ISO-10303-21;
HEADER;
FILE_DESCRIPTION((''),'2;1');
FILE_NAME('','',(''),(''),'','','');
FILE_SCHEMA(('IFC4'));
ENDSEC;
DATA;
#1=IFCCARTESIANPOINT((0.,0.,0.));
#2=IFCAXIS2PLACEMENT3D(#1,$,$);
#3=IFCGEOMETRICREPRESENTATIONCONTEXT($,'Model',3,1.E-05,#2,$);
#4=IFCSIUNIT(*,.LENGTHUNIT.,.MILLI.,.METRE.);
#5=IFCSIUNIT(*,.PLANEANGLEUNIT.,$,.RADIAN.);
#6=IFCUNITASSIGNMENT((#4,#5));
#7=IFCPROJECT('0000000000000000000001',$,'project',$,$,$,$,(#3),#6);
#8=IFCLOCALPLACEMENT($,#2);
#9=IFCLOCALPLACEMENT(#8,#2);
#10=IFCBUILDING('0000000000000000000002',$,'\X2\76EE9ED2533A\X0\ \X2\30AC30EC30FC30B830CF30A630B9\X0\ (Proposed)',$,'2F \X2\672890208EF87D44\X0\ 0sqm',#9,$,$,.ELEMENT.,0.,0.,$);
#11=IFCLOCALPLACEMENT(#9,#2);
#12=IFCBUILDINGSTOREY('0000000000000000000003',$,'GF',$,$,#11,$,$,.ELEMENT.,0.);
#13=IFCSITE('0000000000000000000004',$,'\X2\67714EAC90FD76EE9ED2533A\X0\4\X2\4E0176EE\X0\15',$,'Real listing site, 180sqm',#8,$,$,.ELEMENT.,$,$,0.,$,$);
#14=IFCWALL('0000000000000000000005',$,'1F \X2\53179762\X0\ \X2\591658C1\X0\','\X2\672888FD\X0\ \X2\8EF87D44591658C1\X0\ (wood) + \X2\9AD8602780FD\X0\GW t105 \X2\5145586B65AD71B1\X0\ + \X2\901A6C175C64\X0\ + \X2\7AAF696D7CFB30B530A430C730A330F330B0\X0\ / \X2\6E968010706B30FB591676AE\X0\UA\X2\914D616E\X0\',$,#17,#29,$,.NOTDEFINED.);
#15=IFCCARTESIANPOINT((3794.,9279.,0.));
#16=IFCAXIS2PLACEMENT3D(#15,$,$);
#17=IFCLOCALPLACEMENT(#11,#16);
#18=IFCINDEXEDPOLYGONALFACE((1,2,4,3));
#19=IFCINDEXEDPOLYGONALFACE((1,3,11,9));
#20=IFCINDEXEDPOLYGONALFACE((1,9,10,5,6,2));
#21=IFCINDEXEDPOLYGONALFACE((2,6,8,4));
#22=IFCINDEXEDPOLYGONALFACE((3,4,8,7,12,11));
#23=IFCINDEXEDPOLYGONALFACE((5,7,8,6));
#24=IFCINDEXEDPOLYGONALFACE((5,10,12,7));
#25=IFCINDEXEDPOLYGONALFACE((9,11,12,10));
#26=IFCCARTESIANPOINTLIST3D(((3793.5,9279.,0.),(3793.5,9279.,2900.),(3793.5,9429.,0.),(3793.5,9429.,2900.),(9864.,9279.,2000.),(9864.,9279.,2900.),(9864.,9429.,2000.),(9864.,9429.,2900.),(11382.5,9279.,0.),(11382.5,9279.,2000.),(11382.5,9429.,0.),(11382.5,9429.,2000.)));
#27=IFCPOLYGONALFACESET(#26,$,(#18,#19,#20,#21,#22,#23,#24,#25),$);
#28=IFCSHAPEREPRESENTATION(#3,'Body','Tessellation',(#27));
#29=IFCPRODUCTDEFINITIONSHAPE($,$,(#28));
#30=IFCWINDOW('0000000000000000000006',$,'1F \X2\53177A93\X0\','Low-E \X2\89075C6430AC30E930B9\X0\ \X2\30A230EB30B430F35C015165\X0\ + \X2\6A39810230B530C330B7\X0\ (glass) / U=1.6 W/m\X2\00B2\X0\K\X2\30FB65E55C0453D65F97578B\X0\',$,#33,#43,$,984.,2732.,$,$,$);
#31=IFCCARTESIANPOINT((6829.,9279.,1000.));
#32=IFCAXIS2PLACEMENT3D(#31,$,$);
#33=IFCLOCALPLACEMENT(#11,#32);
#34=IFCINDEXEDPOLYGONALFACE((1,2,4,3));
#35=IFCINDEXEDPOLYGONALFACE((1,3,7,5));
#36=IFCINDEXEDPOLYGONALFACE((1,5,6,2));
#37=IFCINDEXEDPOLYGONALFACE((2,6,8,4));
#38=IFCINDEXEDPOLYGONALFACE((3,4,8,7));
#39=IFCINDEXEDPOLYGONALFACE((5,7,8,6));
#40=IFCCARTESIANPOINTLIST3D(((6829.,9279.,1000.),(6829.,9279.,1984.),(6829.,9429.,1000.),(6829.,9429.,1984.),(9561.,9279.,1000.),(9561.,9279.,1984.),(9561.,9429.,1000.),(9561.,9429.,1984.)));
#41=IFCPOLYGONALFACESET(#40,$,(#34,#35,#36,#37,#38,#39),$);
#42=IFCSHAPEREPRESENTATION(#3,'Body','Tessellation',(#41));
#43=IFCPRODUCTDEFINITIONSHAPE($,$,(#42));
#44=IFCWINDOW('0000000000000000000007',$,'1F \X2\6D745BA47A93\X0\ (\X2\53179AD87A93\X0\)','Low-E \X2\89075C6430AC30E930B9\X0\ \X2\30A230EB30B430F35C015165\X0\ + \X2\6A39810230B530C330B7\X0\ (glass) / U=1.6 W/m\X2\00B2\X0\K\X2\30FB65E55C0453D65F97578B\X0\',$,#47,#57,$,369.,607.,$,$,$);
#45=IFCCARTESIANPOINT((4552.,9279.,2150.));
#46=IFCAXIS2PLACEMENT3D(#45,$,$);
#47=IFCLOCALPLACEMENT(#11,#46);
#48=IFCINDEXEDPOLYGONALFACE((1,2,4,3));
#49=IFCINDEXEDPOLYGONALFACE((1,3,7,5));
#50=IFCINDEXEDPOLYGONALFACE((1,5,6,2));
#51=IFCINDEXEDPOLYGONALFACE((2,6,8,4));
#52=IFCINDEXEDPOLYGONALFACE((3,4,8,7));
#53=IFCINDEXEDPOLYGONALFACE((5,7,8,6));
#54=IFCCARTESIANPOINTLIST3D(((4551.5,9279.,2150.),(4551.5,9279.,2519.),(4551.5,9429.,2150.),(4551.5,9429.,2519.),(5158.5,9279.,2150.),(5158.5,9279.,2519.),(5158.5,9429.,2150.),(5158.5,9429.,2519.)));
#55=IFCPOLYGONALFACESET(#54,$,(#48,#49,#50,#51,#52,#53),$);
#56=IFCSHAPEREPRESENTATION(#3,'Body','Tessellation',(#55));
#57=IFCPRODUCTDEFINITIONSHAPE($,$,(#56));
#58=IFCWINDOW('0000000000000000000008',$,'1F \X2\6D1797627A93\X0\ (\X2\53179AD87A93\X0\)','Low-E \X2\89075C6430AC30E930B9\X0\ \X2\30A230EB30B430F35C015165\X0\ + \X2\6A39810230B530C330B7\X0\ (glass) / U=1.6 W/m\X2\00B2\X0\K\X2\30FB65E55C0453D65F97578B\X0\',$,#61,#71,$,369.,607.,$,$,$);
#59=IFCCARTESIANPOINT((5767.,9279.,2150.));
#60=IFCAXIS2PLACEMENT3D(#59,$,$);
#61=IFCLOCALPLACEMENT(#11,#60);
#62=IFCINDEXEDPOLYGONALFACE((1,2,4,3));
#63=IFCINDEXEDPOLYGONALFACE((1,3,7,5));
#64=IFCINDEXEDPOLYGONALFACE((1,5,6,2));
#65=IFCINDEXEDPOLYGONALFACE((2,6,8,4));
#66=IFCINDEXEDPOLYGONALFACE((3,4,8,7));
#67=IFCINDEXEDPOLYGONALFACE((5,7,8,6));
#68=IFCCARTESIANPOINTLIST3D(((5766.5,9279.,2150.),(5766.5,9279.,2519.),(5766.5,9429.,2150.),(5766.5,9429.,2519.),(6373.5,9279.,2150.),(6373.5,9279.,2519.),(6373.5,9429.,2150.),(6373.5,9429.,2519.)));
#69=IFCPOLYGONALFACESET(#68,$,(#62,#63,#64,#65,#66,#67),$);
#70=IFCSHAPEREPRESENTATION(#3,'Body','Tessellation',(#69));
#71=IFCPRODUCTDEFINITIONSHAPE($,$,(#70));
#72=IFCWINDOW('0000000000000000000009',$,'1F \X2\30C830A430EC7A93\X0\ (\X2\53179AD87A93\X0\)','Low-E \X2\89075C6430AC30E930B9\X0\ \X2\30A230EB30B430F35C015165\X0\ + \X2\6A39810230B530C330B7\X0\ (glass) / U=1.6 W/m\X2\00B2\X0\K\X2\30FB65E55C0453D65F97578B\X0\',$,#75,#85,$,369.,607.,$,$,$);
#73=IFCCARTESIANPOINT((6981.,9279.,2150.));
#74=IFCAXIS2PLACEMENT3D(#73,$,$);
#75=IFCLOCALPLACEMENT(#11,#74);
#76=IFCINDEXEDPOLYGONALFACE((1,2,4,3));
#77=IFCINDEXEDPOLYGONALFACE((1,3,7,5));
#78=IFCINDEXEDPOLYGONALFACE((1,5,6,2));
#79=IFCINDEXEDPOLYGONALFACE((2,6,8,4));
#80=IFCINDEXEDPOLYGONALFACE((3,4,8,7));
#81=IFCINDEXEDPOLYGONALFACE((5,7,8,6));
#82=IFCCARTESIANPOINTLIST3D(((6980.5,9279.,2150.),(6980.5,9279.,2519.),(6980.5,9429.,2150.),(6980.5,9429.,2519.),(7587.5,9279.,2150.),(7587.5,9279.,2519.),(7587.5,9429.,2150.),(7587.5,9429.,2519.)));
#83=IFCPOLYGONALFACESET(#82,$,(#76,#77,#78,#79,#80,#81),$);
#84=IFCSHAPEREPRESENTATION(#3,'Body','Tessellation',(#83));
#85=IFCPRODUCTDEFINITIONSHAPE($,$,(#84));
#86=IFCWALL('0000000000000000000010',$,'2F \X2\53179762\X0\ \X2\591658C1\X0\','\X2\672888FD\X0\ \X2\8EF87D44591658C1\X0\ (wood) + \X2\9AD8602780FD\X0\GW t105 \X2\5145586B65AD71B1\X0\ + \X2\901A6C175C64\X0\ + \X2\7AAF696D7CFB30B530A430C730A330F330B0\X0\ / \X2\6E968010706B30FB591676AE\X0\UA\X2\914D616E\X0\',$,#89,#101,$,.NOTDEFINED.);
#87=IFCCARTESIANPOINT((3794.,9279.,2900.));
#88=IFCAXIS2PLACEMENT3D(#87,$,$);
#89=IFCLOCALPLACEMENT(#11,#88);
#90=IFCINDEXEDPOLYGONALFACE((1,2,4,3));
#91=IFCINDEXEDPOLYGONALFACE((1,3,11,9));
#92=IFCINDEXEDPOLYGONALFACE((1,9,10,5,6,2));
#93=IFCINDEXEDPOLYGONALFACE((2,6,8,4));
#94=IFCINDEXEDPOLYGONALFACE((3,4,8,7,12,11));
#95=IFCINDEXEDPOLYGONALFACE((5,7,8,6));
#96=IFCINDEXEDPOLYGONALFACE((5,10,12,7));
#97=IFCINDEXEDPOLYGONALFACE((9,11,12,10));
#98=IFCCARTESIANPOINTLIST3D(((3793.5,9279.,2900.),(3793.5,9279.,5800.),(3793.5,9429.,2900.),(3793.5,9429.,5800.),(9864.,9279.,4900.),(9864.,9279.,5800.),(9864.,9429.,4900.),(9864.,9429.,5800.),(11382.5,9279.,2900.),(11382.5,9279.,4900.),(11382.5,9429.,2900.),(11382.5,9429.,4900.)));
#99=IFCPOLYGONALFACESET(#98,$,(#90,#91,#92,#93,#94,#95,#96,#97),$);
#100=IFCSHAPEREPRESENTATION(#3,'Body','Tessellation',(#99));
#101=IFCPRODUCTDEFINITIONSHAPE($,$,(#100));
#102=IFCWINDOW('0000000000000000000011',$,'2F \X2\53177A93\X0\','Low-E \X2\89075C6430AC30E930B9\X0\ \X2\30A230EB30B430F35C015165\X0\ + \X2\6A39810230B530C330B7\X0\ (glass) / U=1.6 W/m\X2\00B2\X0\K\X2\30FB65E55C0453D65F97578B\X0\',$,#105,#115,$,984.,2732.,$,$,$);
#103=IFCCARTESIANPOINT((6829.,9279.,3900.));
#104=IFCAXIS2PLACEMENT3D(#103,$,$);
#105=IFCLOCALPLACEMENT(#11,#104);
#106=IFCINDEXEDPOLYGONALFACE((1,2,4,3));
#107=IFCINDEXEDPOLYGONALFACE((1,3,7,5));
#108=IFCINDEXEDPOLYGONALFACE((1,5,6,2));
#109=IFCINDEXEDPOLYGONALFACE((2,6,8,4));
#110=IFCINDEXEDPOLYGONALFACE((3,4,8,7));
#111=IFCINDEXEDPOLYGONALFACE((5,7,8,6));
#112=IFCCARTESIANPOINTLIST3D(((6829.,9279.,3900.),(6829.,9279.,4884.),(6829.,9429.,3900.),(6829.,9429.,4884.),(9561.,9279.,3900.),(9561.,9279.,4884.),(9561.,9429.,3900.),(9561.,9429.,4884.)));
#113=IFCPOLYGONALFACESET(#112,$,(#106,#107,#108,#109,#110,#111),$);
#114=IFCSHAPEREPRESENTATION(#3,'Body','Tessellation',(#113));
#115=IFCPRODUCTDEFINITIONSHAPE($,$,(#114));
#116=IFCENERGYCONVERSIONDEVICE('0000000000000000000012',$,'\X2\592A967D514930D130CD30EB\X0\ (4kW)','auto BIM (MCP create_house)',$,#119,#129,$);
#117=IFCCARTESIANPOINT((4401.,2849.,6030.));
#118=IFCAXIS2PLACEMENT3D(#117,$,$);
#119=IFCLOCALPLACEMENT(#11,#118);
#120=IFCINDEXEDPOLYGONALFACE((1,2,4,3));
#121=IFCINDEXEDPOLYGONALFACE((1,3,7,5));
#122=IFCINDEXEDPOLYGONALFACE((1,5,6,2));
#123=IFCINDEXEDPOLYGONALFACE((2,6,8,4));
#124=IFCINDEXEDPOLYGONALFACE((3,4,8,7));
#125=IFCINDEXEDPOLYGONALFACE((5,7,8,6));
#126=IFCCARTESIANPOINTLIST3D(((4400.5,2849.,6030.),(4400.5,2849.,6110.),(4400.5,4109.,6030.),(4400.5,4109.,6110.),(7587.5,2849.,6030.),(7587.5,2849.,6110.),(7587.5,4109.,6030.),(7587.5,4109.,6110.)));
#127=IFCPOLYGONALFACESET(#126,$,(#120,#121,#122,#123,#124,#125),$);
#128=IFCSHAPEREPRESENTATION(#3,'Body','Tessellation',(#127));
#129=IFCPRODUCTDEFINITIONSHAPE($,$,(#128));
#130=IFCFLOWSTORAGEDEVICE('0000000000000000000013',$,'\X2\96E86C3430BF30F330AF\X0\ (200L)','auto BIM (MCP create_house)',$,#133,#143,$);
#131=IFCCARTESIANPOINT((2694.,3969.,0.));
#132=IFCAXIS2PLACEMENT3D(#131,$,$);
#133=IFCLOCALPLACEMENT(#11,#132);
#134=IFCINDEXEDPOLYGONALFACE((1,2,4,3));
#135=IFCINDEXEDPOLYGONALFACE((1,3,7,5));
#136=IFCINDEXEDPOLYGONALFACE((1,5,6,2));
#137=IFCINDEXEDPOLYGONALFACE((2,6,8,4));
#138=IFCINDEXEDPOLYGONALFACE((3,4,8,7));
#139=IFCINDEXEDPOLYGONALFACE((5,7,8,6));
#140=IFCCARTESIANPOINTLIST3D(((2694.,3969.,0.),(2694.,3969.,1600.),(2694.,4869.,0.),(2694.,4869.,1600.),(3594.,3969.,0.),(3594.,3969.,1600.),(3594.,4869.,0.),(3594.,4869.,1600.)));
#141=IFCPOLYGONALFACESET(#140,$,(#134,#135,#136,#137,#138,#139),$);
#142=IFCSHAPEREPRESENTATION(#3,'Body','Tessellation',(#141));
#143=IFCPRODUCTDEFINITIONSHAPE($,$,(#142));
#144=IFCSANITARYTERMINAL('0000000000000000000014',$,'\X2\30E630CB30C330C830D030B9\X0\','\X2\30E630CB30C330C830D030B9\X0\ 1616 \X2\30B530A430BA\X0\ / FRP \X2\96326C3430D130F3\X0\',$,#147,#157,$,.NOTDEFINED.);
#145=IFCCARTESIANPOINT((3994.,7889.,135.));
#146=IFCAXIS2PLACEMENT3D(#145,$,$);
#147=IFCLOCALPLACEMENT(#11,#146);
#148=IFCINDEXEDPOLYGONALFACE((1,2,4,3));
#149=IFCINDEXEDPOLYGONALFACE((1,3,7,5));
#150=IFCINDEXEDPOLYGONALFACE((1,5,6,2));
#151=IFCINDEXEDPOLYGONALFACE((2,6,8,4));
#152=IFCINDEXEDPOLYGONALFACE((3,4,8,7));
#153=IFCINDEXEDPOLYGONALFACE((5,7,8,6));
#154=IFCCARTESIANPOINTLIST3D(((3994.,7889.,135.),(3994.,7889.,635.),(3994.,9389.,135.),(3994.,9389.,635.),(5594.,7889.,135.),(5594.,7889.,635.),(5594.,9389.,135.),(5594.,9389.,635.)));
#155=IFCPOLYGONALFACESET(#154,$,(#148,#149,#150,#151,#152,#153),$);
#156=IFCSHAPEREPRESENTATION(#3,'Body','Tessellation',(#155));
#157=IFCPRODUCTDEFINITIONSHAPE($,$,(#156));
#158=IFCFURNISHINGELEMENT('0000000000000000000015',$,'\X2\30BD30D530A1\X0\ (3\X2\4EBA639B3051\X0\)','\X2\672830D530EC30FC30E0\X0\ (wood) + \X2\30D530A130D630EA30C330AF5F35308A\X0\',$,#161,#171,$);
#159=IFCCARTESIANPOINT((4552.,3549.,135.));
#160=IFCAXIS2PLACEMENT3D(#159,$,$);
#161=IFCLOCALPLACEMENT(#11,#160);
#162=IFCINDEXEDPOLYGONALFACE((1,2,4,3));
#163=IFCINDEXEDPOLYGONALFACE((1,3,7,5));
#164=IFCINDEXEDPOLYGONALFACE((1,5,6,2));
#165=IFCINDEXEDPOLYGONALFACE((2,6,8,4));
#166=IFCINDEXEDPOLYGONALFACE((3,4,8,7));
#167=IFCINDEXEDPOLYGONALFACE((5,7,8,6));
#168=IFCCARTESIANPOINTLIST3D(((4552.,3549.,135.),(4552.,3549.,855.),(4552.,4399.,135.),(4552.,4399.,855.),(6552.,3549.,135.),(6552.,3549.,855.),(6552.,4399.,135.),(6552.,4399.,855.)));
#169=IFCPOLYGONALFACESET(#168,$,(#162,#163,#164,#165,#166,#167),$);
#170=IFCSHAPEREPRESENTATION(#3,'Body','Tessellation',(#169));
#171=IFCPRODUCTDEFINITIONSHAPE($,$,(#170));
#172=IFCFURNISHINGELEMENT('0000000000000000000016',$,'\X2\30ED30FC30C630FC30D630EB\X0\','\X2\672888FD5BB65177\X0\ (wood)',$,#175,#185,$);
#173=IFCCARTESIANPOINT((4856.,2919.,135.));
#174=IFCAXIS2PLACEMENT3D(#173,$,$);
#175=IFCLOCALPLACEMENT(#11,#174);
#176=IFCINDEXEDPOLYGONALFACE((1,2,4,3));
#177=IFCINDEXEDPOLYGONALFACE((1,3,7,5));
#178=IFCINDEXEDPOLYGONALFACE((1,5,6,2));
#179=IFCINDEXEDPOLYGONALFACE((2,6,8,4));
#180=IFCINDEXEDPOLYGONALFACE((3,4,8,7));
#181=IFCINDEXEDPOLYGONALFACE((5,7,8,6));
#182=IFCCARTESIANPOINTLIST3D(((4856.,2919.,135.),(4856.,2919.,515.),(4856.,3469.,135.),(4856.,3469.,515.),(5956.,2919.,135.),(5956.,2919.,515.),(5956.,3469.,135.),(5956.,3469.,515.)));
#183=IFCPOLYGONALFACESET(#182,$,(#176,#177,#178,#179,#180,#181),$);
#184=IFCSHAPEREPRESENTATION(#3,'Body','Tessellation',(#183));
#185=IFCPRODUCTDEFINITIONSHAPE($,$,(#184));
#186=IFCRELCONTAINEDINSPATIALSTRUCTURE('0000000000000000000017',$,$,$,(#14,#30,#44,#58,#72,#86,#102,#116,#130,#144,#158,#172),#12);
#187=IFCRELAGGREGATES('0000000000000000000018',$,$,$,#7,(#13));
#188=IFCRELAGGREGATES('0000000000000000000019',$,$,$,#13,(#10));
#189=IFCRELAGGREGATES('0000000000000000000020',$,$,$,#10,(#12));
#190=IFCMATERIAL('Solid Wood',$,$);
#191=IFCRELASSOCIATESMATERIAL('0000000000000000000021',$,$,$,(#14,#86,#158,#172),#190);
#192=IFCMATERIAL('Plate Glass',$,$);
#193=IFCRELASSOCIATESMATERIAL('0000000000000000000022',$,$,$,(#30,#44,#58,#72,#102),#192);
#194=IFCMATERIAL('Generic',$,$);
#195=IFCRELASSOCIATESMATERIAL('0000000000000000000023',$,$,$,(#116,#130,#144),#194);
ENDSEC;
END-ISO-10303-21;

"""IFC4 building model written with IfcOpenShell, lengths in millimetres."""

from ifc_helpers import new_model, si_unit, frame, frame_2d, origin, place, context, project, spatial, rectangle, extrude, material, element, fill, save


model = new_model("IFC4")

# Units and contexts
model_context = context("Model", 3, precision=1e-05, world=origin())
ifc_project = project(units=[si_unit("LENGTHUNIT", "METRE", prefix="MILLI"), si_unit("PLANEANGLEUNIT", "RADIAN")], contexts=[model_context])

# Site, building, storey
site_placement = place(None, origin())
site = spatial("IfcSite", under=ifc_project, at=site_placement, Name="東京都目黒区4丁目15", ObjectType="Real listing site, 180sqm", CompositionType="ELEMENT", RefElevation=0.0)
building_placement = place(site_placement, origin())
building = spatial("IfcBuilding", under=site, at=building_placement, Name="目黒区 ガレージハウス (Proposed)", ObjectType="2F 木造軸組 0sqm", CompositionType="ELEMENT", ElevationOfRefHeight=0.0, ElevationOfTerrain=0.0)
storey_placement = place(building_placement, origin())
storey = spatial("IfcBuildingStorey", under=building, at=storey_placement, Name="GF", CompositionType="ELEMENT", Elevation=0.0)

# Wall, openings, windows
ifc_material_1 = material(Name="Solid Wood")
wall_1_placement = place(storey_placement, frame((3794.0, 9279.0, 0.0)))
wall_1 = element("IfcWall", 1, at=wall_1_placement, inside=storey, material=ifc_material_1, Name="1F 北面 外壁", Description="木製 軸組外壁 (wood) + 高性能GW t105 充填断熱 + 通気層 + 窯業系サイディング / 準耐火・外皮UA配慮", PredefinedType="NOTDEFINED", context=model_context, shape_type="SweptSolid", body=[
    extrude(rectangle(XDim=7589.0, YDim=150.0, at=frame_2d((3794.0, 75.0))), frame((3794.0, 9279.0, 0.0)), (0.0, 0.0, 1.0), 2900.0),
])
opening_1_placement = place(storey_placement, frame((6829.0, 9279.0, 1000.0)))
opening_1 = element("IfcOpeningElement", 2, at=opening_1_placement, cuts=wall_1, PredefinedType="NOTDEFINED", context=model_context, shape_type="SweptSolid", body=[
    extrude(rectangle(XDim=2732.0, YDim=150.0, at=frame_2d((1366.0, 75.0))), frame((6829.0, 9279.0, 1000.0)), (0.0, 0.0, 1.0), 984.0),
])
opening_2_placement = place(storey_placement, frame((4552.0, 9279.0, 2150.0)))
opening_2 = element("IfcOpeningElement", 3, at=opening_2_placement, cuts=wall_1, PredefinedType="NOTDEFINED", context=model_context, shape_type="SweptSolid", body=[
    extrude(rectangle(XDim=607.0, YDim=150.0, at=frame_2d((303.0, 75.0))), frame((4552.0, 9279.0, 2150.0)), (0.0, 0.0, 1.0), 369.0),
])
opening_3_placement = place(storey_placement, frame((5767.0, 9279.0, 2150.0)))
opening_3 = element("IfcOpeningElement", 4, at=opening_3_placement, cuts=wall_1, PredefinedType="NOTDEFINED", context=model_context, shape_type="SweptSolid", body=[
    extrude(rectangle(XDim=607.0, YDim=150.0, at=frame_2d((303.0, 75.0))), frame((5767.0, 9279.0, 2150.0)), (0.0, 0.0, 1.0), 369.0),
])
opening_4_placement = place(storey_placement, frame((6981.0, 9279.0, 2150.0)))
opening_4 = element("IfcOpeningElement", 5, at=opening_4_placement, cuts=wall_1, PredefinedType="NOTDEFINED", context=model_context, shape_type="SweptSolid", body=[
    extrude(rectangle(XDim=607.0, YDim=150.0, at=frame_2d((303.0, 75.0))), frame((6981.0, 9279.0, 2150.0)), (0.0, 0.0, 1.0), 369.0),
])
ifc_material_2 = material(Name="Plate Glass")
window_1_placement = place(storey_placement, frame((6829.0, 9279.0, 1000.0)))
window_1 = element("IfcWindow", 6, at=window_1_placement, inside=storey, material=ifc_material_2, Name="1F 北窓", Description="Low-E 複層ガラス アルゴン封入 + 樹脂サッシ (glass) / U=1.6 W/m²K・日射取得型", OverallHeight=984.0, OverallWidth=2732.0, context=model_context, shape_type="SweptSolid", body=[
    extrude(rectangle(XDim=2732.0, YDim=150.0, at=frame_2d((1366.0, 75.0))), frame((6829.0, 9279.0, 1000.0)), (0.0, 0.0, 1.0), 984.0),
])
fill(opening_1, window_1)
window_2_placement = place(storey_placement, frame((4552.0, 9279.0, 2150.0)))
window_2 = element("IfcWindow", 7, at=window_2_placement, inside=storey, material=ifc_material_2, Name="1F 浴室窓 (北高窓)", Description="Low-E 複層ガラス アルゴン封入 + 樹脂サッシ (glass) / U=1.6 W/m²K・日射取得型", OverallHeight=369.0, OverallWidth=607.0, context=model_context, shape_type="SweptSolid", body=[
    extrude(rectangle(XDim=607.0, YDim=150.0, at=frame_2d((303.0, 75.0))), frame((4552.0, 9279.0, 2150.0)), (0.0, 0.0, 1.0), 369.0),
])
fill(opening_2, window_2)
window_3_placement = place(storey_placement, frame((5767.0, 9279.0, 2150.0)))
window_3 = element("IfcWindow", 8, at=window_3_placement, inside=storey, material=ifc_material_2, Name="1F 洗面窓 (北高窓)", Description="Low-E 複層ガラス アルゴン封入 + 樹脂サッシ (glass) / U=1.6 W/m²K・日射取得型", OverallHeight=369.0, OverallWidth=607.0, context=model_context, shape_type="SweptSolid", body=[
    extrude(rectangle(XDim=607.0, YDim=150.0, at=frame_2d((303.0, 75.0))), frame((5767.0, 9279.0, 2150.0)), (0.0, 0.0, 1.0), 369.0),
])
fill(opening_3, window_3)
window_4_placement = place(storey_placement, frame((6981.0, 9279.0, 2150.0)))
window_4 = element("IfcWindow", 9, at=window_4_placement, inside=storey, material=ifc_material_2, Name="1F トイレ窓 (北高窓)", Description="Low-E 複層ガラス アルゴン封入 + 樹脂サッシ (glass) / U=1.6 W/m²K・日射取得型", OverallHeight=369.0, OverallWidth=607.0, context=model_context, shape_type="SweptSolid", body=[
    extrude(rectangle(XDim=607.0, YDim=150.0, at=frame_2d((303.0, 75.0))), frame((6981.0, 9279.0, 2150.0)), (0.0, 0.0, 1.0), 369.0),
])
fill(opening_4, window_4)

# Wall, opening, window
wall_2_placement = place(storey_placement, frame((3794.0, 9279.0, 2900.0)))
wall_2 = element("IfcWall", 10, at=wall_2_placement, inside=storey, material=ifc_material_1, Name="2F 北面 外壁", Description="木製 軸組外壁 (wood) + 高性能GW t105 充填断熱 + 通気層 + 窯業系サイディング / 準耐火・外皮UA配慮", PredefinedType="NOTDEFINED", context=model_context, shape_type="SweptSolid", body=[
    extrude(rectangle(XDim=7589.0, YDim=150.0, at=frame_2d((3794.0, 75.0))), frame((3794.0, 9279.0, 2900.0)), (0.0, 0.0, 1.0), 2900.0),
])
opening_5_placement = place(storey_placement, frame((6829.0, 9279.0, 3900.0)))
opening_5 = element("IfcOpeningElement", 11, at=opening_5_placement, cuts=wall_2, PredefinedType="NOTDEFINED", context=model_context, shape_type="SweptSolid", body=[
    extrude(rectangle(XDim=2732.0, YDim=150.0, at=frame_2d((1366.0, 75.0))), frame((6829.0, 9279.0, 3900.0)), (0.0, 0.0, 1.0), 984.0),
])
window_5_placement = place(storey_placement, frame((6829.0, 9279.0, 3900.0)))
window_5 = element("IfcWindow", 12, at=window_5_placement, inside=storey, material=ifc_material_2, Name="2F 北窓", Description="Low-E 複層ガラス アルゴン封入 + 樹脂サッシ (glass) / U=1.6 W/m²K・日射取得型", OverallHeight=984.0, OverallWidth=2732.0, context=model_context, shape_type="SweptSolid", body=[
    extrude(rectangle(XDim=2732.0, YDim=150.0, at=frame_2d((1366.0, 75.0))), frame((6829.0, 9279.0, 3900.0)), (0.0, 0.0, 1.0), 984.0),
])
fill(opening_5, window_5)

# Energy conversion device
ifc_material_3 = material(Name="Generic")
energy_conversion_device_placement = place(storey_placement, frame((4401.0, 2849.0, 6030.0)))
element("IfcEnergyConversionDevice", 13, at=energy_conversion_device_placement, inside=storey, material=ifc_material_3, Name="太陽光パネル (4kW)", Description="auto BIM (MCP create_house)", context=model_context, shape_type="SweptSolid", body=[
    extrude(rectangle(XDim=3187.0, YDim=1260.0, at=frame_2d((1593.0, 630.0))), frame((4401.0, 2849.0, 6030.0)), (0.0, 0.0, 1.0), 80.0),
])

# Flow storage device
flow_storage_device_placement = place(storey_placement, frame((2694.0, 3969.0, 0.0)))
element("IfcFlowStorageDevice", 14, at=flow_storage_device_placement, inside=storey, material=ifc_material_3, Name="雨水タンク (200L)", Description="auto BIM (MCP create_house)", context=model_context, shape_type="SweptSolid", body=[
    extrude(rectangle(XDim=900.0, YDim=900.0, at=frame_2d((450.0, 450.0))), frame((2694.0, 3969.0, 0.0)), (0.0, 0.0, 1.0), 1600.0),
])

# Sanitary terminal
sanitary_terminal_placement = place(storey_placement, frame((3994.0, 7889.0, 135.0)))
element("IfcSanitaryTerminal", 15, at=sanitary_terminal_placement, inside=storey, material=ifc_material_3, Name="ユニットバス", Description="ユニットバス 1616 サイズ / FRP 防水パン", PredefinedType="NOTDEFINED", context=model_context, shape_type="SweptSolid", body=[
    extrude(rectangle(XDim=1600.0, YDim=1500.0, at=frame_2d((800.0, 750.0))), frame((3994.0, 7889.0, 135.0)), (0.0, 0.0, 1.0), 500.0),
])

# Furnishing elements
furnishing_1_placement = place(storey_placement, frame((4552.0, 3549.0, 135.0)))
element("IfcFurnishingElement", 16, at=furnishing_1_placement, inside=storey, material=ifc_material_1, Name="ソファ (3人掛け)", Description="木フレーム (wood) + ファブリック張り", context=model_context, shape_type="SweptSolid", body=[
    extrude(rectangle(XDim=2000.0, YDim=850.0, at=frame_2d((1000.0, 425.0))), frame((4552.0, 3549.0, 135.0)), (0.0, 0.0, 1.0), 720.0),
])
furnishing_2_placement = place(storey_placement, frame((4856.0, 2919.0, 135.0)))
element("IfcFurnishingElement", 17, at=furnishing_2_placement, inside=storey, material=ifc_material_1, Name="ローテーブル", Description="木製家具 (wood)", context=model_context, shape_type="SweptSolid", body=[
    extrude(rectangle(XDim=1100.0, YDim=550.0, at=frame_2d((550.0, 275.0))), frame((4856.0, 2919.0, 135.0)), (0.0, 0.0, 1.0), 380.0),
])

save(model, "model.ifc")
